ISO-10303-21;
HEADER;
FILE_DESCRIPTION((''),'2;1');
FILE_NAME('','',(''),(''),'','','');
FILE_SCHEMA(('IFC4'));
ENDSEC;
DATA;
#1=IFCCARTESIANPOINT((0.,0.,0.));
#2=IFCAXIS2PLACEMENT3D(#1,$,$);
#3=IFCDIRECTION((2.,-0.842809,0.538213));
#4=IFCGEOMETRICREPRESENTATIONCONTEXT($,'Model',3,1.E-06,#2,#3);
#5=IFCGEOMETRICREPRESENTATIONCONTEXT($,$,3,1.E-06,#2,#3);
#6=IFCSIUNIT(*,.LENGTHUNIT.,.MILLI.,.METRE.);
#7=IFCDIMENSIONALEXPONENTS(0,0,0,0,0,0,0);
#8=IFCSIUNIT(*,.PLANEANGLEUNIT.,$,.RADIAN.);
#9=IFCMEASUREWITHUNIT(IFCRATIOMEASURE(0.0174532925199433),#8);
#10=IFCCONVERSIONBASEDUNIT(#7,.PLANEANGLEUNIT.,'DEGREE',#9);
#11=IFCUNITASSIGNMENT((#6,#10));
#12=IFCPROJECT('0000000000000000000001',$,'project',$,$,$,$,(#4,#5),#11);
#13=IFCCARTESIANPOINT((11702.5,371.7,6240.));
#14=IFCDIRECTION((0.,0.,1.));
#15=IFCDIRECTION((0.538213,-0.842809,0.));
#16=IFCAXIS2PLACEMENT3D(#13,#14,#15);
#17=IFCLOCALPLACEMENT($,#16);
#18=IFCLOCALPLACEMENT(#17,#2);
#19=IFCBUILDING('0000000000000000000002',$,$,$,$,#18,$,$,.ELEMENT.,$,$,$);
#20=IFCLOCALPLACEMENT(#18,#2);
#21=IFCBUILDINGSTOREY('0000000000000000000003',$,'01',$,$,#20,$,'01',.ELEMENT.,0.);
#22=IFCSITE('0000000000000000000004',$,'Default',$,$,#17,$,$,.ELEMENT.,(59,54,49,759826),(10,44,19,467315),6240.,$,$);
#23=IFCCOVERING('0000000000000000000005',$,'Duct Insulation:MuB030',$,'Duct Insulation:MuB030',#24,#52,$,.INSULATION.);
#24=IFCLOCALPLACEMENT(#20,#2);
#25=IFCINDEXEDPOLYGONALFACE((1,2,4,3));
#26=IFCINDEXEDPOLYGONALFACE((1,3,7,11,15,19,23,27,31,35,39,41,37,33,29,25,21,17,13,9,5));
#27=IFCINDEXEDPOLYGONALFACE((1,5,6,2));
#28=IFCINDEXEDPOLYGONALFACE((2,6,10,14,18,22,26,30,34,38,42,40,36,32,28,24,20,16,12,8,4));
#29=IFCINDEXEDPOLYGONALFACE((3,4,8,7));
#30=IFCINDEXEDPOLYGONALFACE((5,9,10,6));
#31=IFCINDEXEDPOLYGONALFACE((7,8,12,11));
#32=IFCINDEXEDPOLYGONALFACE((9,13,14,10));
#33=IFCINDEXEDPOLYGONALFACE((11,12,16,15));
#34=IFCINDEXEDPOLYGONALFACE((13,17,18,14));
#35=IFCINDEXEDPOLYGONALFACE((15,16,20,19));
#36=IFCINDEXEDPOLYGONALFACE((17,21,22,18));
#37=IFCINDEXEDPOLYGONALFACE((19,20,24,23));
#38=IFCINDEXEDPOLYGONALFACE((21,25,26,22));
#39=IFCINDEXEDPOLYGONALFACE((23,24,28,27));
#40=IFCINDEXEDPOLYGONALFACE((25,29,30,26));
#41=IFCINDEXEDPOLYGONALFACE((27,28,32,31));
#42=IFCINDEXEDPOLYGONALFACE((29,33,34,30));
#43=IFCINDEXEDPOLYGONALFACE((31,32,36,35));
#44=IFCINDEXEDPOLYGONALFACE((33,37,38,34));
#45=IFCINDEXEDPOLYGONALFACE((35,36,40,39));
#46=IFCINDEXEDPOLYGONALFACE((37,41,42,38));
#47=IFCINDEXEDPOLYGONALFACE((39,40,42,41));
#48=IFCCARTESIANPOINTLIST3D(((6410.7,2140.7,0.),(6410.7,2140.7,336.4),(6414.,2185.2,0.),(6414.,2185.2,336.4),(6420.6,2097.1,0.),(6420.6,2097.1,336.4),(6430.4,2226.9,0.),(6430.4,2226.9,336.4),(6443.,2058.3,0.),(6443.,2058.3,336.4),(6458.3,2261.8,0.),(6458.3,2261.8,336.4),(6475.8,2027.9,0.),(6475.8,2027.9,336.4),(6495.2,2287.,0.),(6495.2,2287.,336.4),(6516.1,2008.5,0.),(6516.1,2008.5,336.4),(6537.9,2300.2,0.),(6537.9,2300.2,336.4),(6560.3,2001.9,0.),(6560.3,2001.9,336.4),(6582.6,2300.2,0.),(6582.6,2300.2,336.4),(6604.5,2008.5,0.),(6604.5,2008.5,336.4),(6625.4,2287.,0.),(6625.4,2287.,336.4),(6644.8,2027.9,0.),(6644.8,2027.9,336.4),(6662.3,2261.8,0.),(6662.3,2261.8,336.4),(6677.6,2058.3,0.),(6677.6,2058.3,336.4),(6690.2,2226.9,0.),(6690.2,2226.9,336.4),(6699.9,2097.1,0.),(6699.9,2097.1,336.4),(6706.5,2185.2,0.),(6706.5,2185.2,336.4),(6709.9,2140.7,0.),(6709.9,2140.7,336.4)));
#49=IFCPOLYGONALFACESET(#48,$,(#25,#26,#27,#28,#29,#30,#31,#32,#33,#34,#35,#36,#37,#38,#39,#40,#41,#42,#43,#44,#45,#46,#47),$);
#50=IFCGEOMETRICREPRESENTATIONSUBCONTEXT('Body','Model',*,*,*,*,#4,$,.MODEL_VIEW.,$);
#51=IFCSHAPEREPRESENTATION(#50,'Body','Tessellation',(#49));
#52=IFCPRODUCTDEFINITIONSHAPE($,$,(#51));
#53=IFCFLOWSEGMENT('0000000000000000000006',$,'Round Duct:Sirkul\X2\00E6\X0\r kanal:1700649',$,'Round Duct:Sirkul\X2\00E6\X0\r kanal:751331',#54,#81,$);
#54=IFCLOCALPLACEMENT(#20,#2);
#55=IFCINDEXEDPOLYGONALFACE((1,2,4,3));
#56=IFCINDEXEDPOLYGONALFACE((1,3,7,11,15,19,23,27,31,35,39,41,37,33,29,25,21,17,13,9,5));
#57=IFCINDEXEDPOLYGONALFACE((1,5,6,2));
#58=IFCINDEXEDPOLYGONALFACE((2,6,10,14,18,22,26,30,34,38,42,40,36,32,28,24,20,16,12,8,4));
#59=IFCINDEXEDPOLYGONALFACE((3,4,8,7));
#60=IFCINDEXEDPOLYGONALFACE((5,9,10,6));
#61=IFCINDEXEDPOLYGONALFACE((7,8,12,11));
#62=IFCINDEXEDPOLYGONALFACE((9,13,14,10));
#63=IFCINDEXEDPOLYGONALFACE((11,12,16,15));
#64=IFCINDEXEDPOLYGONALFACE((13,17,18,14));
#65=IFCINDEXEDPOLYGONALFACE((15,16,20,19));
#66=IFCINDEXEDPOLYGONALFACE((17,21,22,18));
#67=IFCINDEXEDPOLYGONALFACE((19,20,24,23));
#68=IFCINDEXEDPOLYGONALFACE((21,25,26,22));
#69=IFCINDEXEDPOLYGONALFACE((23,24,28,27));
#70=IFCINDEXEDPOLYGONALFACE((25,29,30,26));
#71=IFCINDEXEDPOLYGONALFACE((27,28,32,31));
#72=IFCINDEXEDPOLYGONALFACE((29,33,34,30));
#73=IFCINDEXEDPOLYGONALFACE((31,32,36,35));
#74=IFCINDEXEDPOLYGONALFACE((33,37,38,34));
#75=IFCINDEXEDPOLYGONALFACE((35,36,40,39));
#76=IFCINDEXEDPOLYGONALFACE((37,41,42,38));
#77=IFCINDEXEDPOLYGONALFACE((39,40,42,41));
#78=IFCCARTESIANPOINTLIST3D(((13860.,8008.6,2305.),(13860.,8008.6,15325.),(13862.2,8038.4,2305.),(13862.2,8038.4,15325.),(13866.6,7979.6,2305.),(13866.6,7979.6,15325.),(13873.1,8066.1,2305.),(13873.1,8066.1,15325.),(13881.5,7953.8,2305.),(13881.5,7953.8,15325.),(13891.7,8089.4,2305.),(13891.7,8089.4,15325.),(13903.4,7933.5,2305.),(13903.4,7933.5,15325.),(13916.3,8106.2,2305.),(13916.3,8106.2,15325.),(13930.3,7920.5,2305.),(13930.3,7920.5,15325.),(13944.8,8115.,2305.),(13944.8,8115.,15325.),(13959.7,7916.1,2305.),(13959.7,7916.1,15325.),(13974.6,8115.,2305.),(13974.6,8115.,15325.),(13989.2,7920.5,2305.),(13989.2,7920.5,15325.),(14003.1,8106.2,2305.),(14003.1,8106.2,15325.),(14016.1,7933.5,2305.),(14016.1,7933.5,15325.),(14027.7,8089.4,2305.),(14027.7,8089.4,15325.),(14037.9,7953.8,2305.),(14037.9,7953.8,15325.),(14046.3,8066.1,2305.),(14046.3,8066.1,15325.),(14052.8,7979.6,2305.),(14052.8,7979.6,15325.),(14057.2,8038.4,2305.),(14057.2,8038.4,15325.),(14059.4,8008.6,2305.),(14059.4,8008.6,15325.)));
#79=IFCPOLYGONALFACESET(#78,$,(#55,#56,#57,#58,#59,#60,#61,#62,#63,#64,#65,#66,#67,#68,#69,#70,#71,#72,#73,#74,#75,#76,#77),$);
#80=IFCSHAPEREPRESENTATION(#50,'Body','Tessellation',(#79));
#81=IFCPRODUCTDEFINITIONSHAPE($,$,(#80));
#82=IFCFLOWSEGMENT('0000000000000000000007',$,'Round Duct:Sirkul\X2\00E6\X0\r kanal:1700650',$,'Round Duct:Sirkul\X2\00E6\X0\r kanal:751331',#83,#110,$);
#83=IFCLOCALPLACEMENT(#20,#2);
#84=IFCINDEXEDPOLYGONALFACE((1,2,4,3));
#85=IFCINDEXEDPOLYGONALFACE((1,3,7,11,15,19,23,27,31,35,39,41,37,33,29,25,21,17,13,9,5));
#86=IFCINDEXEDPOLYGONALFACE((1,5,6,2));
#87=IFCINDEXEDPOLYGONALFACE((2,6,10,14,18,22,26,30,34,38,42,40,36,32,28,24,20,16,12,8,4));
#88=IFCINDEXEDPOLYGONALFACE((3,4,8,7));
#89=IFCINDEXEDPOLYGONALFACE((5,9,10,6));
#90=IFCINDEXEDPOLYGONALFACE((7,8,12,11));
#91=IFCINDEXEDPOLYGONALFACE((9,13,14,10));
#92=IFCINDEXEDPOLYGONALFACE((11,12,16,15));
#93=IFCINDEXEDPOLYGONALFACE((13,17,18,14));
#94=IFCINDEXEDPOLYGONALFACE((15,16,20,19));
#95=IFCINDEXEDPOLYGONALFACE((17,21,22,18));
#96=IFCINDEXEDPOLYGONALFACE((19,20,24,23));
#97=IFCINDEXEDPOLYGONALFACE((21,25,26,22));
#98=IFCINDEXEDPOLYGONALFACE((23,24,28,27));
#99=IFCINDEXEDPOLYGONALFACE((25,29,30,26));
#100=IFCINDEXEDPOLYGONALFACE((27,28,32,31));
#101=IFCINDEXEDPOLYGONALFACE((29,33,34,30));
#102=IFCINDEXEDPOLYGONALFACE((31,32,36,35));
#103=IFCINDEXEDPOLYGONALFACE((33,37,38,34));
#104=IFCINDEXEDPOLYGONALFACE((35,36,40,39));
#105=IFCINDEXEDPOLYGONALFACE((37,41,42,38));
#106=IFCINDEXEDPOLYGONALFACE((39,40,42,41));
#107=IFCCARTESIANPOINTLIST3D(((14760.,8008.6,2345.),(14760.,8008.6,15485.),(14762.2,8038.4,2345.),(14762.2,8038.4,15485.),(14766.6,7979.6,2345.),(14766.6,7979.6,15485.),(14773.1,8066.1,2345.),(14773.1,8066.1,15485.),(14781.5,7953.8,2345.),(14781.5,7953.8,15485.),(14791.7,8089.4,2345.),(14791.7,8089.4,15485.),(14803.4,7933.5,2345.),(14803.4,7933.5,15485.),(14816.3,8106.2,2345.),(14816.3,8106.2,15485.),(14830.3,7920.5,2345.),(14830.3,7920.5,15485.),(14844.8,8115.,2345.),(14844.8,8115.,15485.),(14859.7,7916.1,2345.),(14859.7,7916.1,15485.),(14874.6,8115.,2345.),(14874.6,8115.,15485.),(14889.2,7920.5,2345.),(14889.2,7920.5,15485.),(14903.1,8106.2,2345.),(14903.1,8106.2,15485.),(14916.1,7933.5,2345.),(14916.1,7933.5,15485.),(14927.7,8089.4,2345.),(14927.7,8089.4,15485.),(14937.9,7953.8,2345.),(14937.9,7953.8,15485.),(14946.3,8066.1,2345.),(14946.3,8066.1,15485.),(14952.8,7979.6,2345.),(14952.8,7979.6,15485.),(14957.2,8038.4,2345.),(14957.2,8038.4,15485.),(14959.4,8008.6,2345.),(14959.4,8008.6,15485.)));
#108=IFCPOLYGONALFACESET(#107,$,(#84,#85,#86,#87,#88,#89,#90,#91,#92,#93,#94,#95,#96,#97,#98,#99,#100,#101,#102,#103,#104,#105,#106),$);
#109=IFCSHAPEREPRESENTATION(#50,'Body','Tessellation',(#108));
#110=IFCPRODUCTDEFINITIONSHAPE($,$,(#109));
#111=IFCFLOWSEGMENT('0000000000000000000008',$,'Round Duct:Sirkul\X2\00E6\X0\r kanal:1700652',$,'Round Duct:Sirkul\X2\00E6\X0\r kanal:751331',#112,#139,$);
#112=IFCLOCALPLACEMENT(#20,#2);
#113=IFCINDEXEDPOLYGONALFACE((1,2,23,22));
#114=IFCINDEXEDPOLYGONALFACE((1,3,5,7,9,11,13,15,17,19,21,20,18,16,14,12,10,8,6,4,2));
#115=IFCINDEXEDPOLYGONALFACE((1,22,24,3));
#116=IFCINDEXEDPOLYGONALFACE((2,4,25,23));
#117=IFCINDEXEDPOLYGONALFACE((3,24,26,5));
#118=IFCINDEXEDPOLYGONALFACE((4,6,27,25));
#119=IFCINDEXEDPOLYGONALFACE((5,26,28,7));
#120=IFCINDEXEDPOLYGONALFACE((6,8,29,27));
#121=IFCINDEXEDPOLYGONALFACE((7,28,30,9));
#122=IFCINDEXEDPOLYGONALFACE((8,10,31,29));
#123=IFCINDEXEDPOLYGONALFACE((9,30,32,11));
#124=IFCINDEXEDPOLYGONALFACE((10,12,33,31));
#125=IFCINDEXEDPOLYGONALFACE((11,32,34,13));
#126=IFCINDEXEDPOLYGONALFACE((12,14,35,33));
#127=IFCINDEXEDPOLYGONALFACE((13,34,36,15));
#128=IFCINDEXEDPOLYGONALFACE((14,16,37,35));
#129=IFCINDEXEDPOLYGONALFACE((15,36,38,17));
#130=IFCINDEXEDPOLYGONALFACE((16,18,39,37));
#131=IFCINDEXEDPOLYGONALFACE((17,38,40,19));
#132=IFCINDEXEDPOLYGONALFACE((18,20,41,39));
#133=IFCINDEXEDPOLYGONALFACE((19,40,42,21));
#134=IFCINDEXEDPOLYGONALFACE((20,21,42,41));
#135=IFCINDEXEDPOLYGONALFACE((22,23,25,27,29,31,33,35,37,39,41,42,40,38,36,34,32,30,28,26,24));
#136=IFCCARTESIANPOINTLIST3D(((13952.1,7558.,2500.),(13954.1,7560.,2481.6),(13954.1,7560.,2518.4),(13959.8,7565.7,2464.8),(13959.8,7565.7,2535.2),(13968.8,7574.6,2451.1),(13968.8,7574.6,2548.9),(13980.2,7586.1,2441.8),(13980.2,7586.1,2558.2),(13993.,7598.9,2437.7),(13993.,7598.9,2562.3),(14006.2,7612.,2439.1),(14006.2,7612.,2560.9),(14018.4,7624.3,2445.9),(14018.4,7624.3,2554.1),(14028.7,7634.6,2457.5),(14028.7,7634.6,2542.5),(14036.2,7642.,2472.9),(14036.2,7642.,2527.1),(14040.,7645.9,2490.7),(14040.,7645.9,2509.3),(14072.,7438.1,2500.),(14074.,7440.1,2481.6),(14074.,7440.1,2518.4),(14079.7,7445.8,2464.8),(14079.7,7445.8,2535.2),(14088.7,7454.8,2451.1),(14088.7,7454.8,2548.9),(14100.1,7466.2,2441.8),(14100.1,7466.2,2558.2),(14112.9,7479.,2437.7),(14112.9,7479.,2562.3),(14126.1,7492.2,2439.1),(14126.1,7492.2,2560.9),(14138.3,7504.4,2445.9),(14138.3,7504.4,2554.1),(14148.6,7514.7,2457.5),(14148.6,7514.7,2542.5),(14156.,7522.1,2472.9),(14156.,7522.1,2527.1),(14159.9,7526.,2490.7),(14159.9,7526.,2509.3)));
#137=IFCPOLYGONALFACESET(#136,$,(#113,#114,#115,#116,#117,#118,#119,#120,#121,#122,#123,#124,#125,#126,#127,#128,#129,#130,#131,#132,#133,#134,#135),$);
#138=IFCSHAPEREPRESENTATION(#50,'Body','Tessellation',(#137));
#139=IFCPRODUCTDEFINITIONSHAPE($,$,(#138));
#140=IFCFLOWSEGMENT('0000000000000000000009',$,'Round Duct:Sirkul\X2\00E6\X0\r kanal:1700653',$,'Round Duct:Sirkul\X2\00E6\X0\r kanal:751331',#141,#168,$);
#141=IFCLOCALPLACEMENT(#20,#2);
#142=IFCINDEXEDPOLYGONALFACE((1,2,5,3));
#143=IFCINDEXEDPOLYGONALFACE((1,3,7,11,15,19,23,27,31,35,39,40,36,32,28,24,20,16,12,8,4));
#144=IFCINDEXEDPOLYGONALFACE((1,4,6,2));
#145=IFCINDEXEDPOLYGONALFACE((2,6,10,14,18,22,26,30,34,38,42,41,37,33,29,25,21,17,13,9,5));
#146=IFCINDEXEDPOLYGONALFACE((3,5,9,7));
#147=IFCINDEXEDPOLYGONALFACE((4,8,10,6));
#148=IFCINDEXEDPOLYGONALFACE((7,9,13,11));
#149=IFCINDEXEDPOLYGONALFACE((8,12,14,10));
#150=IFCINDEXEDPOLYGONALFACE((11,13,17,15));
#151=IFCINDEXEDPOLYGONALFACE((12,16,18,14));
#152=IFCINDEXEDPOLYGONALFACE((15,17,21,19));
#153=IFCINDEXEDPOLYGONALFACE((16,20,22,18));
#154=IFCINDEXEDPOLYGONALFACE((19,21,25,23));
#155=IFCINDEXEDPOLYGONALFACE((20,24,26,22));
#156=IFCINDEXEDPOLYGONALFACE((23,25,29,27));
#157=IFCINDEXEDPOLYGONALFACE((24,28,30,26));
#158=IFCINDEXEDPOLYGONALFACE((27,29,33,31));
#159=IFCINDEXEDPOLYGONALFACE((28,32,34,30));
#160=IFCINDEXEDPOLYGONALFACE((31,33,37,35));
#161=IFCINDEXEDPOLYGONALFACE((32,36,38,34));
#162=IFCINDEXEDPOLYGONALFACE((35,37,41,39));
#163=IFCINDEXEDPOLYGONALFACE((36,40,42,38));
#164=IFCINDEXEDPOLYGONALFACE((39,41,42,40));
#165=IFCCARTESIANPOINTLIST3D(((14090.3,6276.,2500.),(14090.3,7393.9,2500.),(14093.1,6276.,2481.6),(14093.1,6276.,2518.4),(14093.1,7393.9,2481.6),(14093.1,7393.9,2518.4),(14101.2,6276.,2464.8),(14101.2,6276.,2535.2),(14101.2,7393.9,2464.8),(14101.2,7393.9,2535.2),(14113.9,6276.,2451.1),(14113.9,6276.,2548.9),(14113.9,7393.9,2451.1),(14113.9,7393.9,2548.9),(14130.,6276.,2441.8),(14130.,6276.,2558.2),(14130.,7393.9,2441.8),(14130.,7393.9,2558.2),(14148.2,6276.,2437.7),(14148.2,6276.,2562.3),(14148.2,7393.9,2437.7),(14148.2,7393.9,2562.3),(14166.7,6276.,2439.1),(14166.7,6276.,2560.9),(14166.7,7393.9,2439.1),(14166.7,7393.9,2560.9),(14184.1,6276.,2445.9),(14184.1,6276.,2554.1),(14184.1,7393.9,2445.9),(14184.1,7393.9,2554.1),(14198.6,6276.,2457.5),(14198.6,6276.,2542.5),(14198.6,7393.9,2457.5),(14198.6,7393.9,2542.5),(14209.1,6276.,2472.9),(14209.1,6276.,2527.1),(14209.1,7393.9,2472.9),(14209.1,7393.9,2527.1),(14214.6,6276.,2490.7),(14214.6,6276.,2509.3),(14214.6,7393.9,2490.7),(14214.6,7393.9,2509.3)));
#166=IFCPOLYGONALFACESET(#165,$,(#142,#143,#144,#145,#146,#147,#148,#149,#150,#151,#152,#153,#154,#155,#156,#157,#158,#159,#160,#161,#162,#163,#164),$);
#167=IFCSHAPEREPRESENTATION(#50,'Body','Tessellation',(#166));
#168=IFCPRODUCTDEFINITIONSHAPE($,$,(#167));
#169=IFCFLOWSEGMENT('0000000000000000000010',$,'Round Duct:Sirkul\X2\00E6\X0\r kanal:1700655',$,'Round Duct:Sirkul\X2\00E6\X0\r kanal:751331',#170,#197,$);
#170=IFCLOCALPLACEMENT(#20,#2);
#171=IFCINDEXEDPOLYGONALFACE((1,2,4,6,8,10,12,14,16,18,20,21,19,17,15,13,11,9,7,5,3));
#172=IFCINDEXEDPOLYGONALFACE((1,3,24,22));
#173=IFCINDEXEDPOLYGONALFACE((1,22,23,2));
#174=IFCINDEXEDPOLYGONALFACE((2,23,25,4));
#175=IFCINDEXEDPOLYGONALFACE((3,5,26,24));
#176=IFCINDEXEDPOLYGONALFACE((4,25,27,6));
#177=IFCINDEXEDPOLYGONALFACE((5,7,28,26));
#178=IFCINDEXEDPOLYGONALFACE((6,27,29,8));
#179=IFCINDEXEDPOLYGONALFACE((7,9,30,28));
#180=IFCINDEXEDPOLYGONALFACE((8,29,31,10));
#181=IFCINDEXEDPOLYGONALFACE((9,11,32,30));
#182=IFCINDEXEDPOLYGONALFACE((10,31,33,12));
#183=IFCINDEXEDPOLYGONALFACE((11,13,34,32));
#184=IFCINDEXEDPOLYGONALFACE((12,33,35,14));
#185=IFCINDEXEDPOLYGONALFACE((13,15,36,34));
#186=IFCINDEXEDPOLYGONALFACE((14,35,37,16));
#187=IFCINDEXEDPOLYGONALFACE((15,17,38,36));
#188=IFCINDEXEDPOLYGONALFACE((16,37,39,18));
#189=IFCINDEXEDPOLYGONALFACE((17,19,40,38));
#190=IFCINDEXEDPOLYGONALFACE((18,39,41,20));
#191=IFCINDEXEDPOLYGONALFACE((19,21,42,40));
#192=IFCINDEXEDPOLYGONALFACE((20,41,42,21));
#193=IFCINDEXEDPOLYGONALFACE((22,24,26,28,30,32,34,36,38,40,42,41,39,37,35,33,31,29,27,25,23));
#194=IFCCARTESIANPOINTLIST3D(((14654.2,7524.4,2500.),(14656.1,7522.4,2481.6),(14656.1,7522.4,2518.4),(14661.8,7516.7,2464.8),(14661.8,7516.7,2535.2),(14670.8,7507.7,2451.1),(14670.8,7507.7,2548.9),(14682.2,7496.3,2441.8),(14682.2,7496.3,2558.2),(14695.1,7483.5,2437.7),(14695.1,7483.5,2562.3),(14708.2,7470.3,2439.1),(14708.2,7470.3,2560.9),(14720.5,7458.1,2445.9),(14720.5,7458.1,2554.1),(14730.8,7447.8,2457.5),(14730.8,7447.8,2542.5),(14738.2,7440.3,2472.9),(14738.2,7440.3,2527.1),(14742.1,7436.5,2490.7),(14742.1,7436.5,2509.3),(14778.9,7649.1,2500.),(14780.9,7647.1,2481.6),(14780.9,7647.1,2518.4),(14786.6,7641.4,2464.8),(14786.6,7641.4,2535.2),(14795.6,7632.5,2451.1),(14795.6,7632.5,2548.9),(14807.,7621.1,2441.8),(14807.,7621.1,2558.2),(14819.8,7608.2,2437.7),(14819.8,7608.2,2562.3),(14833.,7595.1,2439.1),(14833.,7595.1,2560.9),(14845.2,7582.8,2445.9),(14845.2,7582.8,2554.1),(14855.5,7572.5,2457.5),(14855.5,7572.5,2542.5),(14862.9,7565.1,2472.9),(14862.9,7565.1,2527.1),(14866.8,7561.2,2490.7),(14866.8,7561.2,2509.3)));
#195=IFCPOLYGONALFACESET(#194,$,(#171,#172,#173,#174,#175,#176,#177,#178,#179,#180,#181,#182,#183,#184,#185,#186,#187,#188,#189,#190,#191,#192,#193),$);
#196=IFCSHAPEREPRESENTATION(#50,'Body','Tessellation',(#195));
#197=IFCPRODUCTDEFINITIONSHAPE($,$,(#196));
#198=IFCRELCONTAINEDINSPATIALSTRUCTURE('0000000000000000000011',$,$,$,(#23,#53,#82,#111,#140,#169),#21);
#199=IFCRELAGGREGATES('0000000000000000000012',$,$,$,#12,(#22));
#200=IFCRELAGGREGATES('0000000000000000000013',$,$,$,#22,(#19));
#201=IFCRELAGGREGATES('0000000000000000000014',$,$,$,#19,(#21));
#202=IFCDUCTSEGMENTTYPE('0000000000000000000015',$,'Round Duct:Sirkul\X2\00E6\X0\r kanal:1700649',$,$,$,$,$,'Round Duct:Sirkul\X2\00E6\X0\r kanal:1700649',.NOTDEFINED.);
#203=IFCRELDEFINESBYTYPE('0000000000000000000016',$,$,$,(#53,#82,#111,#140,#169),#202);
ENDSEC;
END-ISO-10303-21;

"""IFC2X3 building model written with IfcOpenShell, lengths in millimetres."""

from ifc_helpers import new_model, entity, si_unit, converted_unit, direction, frame, frame_2d, origin, origin_2d_with_axis, place, context, subcontext, project, spatial, circle, extrude, type_object, element, save


model = new_model("IFC2X3")

# Units and contexts
model_context = context("Model", 3, precision=1e-06, world=origin(), true_north=direction((2.0, -0.842809, 0.538213)))
context_of_model = context(None, 3, precision=1e-06, world=origin(), true_north=direction((2.0, -0.842809, 0.538213)))
body_context = subcontext(model_context, "Body", "Model", "MODEL_VIEW")
ifc_project = project(units=[si_unit("LENGTHUNIT", "METRE", prefix="MILLI"), converted_unit("PLANEANGLEUNIT", "DEGREE", entity("IfcRatioMeasure", 0.0174532925199433), si_unit("PLANEANGLEUNIT", "RADIAN"), dimensions=[0, 0, 0, 0, 0, 0, 0])], contexts=[model_context, context_of_model])

# Site, building, storey
site_placement = place(None, frame((11702.5, 371.7, 6240.0), z_axis=(0.0, 0.0, 1.0), x_axis=(0.538213, -0.842809, 0.0)))
site = spatial("IfcSite", under=ifc_project, at=site_placement, Name="Default", CompositionType="ELEMENT", RefLatitude=(59, 54, 49, 759826), RefLongitude=(10, 44, 19, 467315), RefElevation=6240.0)
building_placement = place(site_placement, origin())
building = spatial("IfcBuilding", under=site, at=building_placement, CompositionType="ELEMENT")
storey_placement = place(building_placement, origin())
storey = spatial("IfcBuildingStorey", under=building, at=storey_placement, Name="01", LongName="01", CompositionType="ELEMENT", Elevation=0.0)

# Covering
covering_placement = place(storey_placement, origin())
element("IfcCovering", 1, at=covering_placement, inside=storey, Name="Duct Insulation:MuB030", ObjectType="Duct Insulation:MuB030", PredefinedType="INSULATION", context=body_context, shape_type="SweptSolid", body=[
    extrude(circle(Radius=150.0, at=frame_2d((0.0, 0.0), x_axis=(1.0, 0.0))), frame((6560.3, 2151.9, 0.0), z_axis=(0.0, 0.0, 1.0), x_axis=(0.0, -1.0, 0.0)), (0.0, 0.0, 1.0), 336.4),
])

# Flow segments
duct_segment_type = type_object("IfcDuctSegmentType", Name="Round Duct:Sirkulær kanal:1700649", ElementType="Round Duct:Sirkulær kanal:1700649", PredefinedType="NOTDEFINED")
flow_segment_1_placement = place(storey_placement, origin())
element("IfcFlowSegment", 2, at=flow_segment_1_placement, inside=storey, type_object=duct_segment_type, Name="Round Duct:Sirkulær kanal:1700649", ObjectType="Round Duct:Sirkulær kanal:751331", context=body_context, shape_type="SweptSolid", body=[
    extrude(circle(Radius=100.0, at=frame_2d((0.0, 0.0), x_axis=(1.0, 0.0))), frame((13959.7, 8016.1, 2305.0), z_axis=(0.0, 0.0, 1.0), x_axis=(0.0, -1.0, 0.0)), (0.0, 0.0, 1.0), 13020.0),
])
flow_segment_2_placement = place(storey_placement, origin())
element("IfcFlowSegment", 3, at=flow_segment_2_placement, inside=storey, type_object=duct_segment_type, Name="Round Duct:Sirkulær kanal:1700650", ObjectType="Round Duct:Sirkulær kanal:751331", context=body_context, shape_type="SweptSolid", body=[
    extrude(circle(Radius=100.0, at=frame_2d((0.0, 0.0), x_axis=(1.0, 0.0))), frame((14859.7, 8016.1, 2345.0), z_axis=(0.0, 0.0, 1.0), x_axis=(0.0, -1.0, 0.0)), (0.0, 0.0, 1.0), 13140.0),
])
flow_segment_3_placement = place(storey_placement, origin())
element("IfcFlowSegment", 4, at=flow_segment_3_placement, inside=storey, type_object=duct_segment_type, Name="Round Duct:Sirkulær kanal:1700652", ObjectType="Round Duct:Sirkulær kanal:751331", context=body_context, shape_type="SweptSolid", body=[
    extrude(circle(Radius=62.5, at=origin_2d_with_axis()), frame((13996.3, 7602.2, 2500.0), z_axis=(0.707107, -0.707107, 0.0), x_axis=(-0.707107, -0.707107, 0.0)), (0.0, 0.0, 1.0), 169.5),
])
flow_segment_4_placement = place(storey_placement, origin())
element("IfcFlowSegment", 5, at=flow_segment_4_placement, inside=storey, type_object=duct_segment_type, Name="Round Duct:Sirkulær kanal:1700653", ObjectType="Round Duct:Sirkulær kanal:751331", context=body_context, shape_type="SweptSolid", body=[
    extrude(circle(Radius=62.5, at=frame_2d((0.0, 0.0), x_axis=(1.0, 0.0))), frame((14152.8, 6276.0, 2500.0), z_axis=(0.0, 1.0, 0.0), x_axis=(-1.0, 0.0, 0.0)), (0.0, 0.0, 1.0), 1117.9),
])
flow_segment_5_placement = place(storey_placement, origin())
element("IfcFlowSegment", 6, at=flow_segment_5_placement, inside=storey, type_object=duct_segment_type, Name="Round Duct:Sirkulær kanal:1700655", ObjectType="Round Duct:Sirkulær kanal:751331", context=body_context, shape_type="SweptSolid", body=[
    extrude(circle(Radius=62.5, at=origin_2d_with_axis()), frame((14698.4, 7480.2, 2500.0), z_axis=(0.707107, 0.707107, 0.0), x_axis=(-0.707107, 0.707107, 0.0)), (0.0, 0.0, 1.0), 176.4),
])

save(model, "model.ifc")
